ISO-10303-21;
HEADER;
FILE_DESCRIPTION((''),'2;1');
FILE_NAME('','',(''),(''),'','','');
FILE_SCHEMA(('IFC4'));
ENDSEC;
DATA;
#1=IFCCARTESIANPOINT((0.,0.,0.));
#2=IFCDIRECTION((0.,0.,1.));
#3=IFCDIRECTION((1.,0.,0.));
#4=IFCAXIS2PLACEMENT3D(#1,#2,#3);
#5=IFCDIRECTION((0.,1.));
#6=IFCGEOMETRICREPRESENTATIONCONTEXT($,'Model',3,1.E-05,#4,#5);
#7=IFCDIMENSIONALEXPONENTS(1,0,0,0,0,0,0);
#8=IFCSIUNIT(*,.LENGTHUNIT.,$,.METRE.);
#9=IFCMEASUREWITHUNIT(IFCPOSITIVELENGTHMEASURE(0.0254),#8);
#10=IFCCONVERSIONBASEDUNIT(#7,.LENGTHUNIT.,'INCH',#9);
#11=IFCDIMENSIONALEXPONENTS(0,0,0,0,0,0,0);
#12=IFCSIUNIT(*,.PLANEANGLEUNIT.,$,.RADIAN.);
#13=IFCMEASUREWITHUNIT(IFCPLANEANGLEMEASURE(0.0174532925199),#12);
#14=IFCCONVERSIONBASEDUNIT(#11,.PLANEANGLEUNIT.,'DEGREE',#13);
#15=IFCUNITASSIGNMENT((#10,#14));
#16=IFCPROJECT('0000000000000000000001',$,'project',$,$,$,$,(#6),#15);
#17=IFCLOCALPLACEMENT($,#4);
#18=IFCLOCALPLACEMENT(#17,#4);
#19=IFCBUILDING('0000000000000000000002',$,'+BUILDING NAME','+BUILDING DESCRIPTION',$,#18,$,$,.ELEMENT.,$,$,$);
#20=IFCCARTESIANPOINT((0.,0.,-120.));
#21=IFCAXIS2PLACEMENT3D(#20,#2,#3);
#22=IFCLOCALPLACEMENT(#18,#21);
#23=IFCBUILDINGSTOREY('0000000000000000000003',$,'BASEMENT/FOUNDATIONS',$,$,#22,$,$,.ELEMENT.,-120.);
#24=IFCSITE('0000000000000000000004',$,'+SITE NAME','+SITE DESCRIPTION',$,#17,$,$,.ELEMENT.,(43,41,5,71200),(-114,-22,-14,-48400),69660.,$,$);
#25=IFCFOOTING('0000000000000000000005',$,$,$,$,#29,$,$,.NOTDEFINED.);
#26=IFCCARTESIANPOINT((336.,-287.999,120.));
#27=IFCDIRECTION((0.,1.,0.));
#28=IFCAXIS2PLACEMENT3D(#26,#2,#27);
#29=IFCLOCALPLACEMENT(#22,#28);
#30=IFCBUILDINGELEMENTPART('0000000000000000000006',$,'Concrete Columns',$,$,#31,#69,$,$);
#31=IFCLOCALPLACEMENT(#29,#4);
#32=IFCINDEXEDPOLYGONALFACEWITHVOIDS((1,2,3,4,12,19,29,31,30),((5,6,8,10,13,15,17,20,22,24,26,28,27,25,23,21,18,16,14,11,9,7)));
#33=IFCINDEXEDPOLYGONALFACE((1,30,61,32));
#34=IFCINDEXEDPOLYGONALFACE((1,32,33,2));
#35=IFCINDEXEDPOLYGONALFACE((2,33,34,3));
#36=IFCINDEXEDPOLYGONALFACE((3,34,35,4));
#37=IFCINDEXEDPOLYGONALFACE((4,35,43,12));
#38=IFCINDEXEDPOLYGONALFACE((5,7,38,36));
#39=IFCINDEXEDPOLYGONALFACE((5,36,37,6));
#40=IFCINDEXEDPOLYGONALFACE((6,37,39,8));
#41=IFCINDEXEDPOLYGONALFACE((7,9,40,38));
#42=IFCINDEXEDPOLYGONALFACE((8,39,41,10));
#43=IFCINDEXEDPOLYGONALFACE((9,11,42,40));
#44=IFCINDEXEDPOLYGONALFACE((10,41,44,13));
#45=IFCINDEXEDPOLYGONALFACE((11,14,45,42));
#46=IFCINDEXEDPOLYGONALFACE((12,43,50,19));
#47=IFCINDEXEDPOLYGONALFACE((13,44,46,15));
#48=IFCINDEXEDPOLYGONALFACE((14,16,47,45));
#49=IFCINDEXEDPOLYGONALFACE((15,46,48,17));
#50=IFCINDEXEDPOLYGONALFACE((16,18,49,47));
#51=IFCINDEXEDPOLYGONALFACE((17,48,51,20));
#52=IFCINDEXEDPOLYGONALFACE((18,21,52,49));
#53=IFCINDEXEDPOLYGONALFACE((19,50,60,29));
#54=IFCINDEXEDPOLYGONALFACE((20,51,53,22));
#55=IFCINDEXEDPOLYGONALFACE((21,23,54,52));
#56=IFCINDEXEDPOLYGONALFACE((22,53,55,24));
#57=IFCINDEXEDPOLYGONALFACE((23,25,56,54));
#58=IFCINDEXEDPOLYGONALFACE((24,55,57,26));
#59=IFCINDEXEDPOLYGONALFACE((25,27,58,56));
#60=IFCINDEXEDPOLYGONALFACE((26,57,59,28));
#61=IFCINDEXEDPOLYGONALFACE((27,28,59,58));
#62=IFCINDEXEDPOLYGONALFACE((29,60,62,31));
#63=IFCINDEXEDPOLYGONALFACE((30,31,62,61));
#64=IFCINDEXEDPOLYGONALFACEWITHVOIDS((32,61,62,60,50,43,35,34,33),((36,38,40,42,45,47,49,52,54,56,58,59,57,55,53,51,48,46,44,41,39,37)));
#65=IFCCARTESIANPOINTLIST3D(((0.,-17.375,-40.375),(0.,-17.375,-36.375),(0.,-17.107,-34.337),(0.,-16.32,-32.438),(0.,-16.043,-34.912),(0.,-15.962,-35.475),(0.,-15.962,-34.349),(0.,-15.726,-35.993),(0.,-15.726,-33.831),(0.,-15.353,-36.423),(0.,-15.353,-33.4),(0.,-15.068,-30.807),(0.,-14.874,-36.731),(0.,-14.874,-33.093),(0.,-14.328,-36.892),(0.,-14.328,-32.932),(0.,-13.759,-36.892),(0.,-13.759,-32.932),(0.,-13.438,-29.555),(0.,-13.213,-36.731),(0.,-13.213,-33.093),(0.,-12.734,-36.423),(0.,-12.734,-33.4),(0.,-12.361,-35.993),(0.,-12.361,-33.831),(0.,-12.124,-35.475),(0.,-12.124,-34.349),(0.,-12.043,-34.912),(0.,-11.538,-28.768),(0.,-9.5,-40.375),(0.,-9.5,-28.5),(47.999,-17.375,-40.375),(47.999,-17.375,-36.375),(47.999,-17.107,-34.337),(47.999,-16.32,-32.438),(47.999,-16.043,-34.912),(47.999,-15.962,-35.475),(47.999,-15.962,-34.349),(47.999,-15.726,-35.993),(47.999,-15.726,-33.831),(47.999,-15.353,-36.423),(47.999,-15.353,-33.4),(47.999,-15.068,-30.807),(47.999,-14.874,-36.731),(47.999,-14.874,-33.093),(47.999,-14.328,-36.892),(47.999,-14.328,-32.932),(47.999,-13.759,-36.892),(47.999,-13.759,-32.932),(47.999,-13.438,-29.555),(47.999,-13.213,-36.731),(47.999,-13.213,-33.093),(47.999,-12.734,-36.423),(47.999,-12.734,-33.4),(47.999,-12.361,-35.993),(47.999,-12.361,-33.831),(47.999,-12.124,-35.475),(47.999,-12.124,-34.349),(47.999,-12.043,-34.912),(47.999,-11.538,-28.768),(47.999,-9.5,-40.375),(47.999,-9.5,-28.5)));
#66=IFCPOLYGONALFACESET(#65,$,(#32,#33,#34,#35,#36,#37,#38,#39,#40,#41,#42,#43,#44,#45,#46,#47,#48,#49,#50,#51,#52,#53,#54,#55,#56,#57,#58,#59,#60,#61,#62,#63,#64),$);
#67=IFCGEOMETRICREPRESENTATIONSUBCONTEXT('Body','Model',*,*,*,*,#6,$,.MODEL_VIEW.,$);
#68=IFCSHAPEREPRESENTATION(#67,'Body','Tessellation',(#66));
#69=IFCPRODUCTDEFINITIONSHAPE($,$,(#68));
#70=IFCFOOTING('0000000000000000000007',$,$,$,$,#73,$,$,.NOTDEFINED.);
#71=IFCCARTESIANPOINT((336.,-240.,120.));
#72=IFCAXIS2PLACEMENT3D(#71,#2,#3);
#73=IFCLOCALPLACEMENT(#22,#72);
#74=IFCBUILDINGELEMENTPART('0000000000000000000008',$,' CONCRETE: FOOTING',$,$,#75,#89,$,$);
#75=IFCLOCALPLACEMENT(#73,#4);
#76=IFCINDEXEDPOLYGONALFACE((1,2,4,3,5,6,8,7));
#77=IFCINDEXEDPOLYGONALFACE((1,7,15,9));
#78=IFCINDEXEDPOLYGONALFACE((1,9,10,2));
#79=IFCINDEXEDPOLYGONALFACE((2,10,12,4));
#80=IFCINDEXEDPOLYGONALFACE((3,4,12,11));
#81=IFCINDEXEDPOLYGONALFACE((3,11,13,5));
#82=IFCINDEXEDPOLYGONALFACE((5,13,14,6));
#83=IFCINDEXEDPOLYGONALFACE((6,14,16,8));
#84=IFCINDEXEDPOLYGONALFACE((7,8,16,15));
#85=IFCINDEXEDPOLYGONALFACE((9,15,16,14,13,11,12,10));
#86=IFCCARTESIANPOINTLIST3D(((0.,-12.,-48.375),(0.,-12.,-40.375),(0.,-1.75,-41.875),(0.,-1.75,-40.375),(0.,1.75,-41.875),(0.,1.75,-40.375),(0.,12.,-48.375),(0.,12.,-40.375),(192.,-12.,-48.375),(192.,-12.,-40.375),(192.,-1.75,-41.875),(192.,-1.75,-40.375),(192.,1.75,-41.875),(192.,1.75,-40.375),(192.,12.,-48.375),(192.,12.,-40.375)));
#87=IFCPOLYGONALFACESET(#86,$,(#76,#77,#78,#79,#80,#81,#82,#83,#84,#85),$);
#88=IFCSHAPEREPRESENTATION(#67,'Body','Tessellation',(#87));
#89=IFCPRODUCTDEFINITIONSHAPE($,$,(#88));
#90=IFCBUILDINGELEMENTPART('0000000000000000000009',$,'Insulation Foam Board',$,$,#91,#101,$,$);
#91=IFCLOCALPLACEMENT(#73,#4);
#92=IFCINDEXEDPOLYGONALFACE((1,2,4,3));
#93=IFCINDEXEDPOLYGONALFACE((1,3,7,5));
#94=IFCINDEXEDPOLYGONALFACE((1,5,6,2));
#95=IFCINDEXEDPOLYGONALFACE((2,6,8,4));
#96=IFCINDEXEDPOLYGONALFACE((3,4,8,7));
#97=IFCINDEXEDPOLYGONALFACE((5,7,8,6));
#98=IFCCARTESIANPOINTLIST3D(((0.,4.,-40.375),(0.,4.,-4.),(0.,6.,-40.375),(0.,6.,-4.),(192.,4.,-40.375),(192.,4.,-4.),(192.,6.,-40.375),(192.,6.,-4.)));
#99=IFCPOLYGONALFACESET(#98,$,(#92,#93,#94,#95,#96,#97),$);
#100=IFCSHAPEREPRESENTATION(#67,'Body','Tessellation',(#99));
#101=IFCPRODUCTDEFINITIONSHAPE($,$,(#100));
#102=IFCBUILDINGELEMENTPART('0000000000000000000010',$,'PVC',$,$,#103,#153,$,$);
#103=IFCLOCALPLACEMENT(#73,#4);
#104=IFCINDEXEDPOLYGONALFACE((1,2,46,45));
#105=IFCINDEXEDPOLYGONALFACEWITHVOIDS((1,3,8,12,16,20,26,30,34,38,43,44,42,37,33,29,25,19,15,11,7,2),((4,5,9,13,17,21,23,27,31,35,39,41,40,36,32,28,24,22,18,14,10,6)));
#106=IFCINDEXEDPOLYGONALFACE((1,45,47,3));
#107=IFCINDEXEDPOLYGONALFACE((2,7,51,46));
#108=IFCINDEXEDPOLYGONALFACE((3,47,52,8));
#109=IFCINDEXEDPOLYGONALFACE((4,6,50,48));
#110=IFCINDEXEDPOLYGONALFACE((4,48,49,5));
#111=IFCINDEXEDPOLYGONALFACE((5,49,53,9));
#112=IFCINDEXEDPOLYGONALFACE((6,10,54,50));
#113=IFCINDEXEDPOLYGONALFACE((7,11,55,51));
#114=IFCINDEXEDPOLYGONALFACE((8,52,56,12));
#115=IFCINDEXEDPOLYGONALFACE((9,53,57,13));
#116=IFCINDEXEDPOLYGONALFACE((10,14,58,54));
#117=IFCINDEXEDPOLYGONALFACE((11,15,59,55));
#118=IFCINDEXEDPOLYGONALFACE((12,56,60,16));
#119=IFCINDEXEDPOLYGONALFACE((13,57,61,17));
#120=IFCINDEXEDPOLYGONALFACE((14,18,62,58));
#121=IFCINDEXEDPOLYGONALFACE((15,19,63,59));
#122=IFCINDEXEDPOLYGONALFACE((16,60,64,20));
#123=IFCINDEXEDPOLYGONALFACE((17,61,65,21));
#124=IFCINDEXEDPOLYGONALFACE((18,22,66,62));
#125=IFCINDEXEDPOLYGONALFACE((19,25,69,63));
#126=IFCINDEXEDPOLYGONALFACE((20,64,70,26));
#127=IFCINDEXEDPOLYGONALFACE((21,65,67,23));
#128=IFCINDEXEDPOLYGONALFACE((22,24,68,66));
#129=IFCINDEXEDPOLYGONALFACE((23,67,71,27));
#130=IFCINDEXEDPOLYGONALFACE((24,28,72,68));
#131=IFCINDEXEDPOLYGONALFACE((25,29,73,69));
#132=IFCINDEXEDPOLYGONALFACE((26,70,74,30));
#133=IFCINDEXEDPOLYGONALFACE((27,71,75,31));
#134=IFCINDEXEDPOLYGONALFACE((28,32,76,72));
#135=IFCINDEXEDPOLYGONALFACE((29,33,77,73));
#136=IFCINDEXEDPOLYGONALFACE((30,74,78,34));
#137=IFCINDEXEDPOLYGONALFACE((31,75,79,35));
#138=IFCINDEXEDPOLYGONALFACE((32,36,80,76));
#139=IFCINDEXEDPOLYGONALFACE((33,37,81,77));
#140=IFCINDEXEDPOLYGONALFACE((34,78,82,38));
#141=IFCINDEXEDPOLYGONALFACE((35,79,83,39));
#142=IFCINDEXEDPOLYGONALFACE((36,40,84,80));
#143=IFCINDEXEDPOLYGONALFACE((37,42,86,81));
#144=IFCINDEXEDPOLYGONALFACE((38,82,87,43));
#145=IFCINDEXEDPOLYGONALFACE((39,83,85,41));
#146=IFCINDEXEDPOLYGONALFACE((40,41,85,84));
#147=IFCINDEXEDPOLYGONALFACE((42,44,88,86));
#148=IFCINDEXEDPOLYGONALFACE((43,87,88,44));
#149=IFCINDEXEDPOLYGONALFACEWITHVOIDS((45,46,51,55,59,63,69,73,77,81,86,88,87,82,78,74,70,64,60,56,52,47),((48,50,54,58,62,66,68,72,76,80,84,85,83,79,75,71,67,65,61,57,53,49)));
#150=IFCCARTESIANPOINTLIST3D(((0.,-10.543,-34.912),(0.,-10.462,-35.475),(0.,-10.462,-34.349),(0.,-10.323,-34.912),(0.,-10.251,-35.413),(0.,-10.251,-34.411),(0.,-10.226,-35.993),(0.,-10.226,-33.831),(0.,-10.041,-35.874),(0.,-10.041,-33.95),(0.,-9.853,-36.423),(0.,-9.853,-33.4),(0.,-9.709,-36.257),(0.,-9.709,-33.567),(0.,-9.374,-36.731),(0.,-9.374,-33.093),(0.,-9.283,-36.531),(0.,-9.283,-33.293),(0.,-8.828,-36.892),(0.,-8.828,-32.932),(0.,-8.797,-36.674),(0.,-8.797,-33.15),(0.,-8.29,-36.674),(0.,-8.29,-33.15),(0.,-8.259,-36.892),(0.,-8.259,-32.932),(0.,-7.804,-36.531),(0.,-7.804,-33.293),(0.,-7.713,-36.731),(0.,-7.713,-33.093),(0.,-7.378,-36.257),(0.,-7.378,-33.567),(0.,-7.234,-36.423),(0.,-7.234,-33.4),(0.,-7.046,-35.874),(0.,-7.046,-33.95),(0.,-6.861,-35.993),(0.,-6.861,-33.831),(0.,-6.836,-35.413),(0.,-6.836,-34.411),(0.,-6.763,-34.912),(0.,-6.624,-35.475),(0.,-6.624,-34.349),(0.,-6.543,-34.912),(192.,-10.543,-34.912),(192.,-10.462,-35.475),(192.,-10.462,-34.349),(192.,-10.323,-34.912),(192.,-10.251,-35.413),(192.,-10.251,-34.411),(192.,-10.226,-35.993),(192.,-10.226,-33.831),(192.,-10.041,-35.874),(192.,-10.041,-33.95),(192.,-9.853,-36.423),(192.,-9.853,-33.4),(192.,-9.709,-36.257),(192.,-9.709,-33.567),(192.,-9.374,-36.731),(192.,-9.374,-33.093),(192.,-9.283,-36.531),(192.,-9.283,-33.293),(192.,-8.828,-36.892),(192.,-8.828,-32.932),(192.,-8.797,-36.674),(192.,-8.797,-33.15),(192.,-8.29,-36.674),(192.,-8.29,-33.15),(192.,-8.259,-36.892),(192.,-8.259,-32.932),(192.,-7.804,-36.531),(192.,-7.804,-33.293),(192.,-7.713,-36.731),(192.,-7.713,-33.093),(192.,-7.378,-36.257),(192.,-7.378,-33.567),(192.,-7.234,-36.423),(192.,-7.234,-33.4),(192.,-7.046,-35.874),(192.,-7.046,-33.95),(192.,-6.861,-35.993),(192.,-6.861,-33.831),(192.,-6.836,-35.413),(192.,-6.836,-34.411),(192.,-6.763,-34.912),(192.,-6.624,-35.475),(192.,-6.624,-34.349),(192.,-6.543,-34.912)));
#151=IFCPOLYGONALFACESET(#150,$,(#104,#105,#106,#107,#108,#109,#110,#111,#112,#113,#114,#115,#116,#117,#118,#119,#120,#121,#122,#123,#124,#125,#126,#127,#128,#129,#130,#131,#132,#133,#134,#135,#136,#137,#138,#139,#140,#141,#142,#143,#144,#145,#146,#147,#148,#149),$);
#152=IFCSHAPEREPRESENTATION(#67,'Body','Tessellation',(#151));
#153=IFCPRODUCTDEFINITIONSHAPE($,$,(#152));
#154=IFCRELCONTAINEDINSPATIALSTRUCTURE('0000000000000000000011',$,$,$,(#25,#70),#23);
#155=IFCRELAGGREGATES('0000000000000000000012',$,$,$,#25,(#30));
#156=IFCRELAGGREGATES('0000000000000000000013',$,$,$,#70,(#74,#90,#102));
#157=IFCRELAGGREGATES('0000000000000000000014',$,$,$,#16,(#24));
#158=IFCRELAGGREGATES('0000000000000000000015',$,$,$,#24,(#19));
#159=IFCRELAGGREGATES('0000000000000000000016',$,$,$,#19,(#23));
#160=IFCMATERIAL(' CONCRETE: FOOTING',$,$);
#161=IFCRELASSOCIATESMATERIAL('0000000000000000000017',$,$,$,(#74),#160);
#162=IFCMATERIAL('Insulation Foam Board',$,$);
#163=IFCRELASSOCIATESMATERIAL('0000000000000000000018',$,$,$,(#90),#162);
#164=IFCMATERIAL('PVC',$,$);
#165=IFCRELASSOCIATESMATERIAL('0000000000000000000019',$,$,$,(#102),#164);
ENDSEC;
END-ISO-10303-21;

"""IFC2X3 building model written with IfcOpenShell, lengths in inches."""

from ifc_helpers import new_model, entity, si_unit, converted_unit, point, direction, frame, frame_2d, origin_with_axes, place, context, subcontext, project, spatial, polyline, circle_curve, parameter, trimmed, segment, composite_curve, outline, extrude, material, element, aggregate, save


model = new_model("IFC2X3")

# Units and contexts
model_context = context("Model", 3, precision=1e-05, world=origin_with_axes(), true_north=direction((0.0, 1.0)))
body_context = subcontext(model_context, "Body", "Model", "MODEL_VIEW")
ifc_project = project(units=[converted_unit("LENGTHUNIT", "INCH", entity("IfcPositiveLengthMeasure", 0.0254), si_unit("LENGTHUNIT", "METRE"), dimensions=[1, 0, 0, 0, 0, 0, 0]), converted_unit("PLANEANGLEUNIT", "DEGREE", entity("IfcPlaneAngleMeasure", 0.0174532925199), si_unit("PLANEANGLEUNIT", "RADIAN"), dimensions=[0, 0, 0, 0, 0, 0, 0])], contexts=[model_context])

# Site, building, storey
site_placement = place(None, origin_with_axes())
site = spatial("IfcSite", under=ifc_project, at=site_placement, Name="+SITE NAME", Description="+SITE DESCRIPTION", CompositionType="ELEMENT", RefLatitude=(43, 41, 5, 71200), RefLongitude=(-114, -22, -14, -48400), RefElevation=69660.0)
building_placement = place(site_placement, origin_with_axes())
building = spatial("IfcBuilding", under=site, at=building_placement, Name="+BUILDING NAME", Description="+BUILDING DESCRIPTION", CompositionType="ELEMENT")
storey_placement = place(building_placement, frame((0.0, 0.0, -120.0), z_axis=(0.0, 0.0, 1.0), x_axis=(1.0, 0.0, 0.0)))
storey = spatial("IfcBuildingStorey", under=building, at=storey_placement, Name="BASEMENT/FOUNDATIONS", CompositionType="ELEMENT", Elevation=-120.0)

# Footings, building element parts
ifc_material_1 = material(Name=" CONCRETE: FOOTING")
footing_1_placement = place(storey_placement, frame((336.0, -287.999, 120.0), z_axis=(0.0, 0.0, 1.0), x_axis=(0.0, 1.0, 0.0)))
footing_1 = element("IfcFooting", 1, at=footing_1_placement, inside=storey, PredefinedType="NOTDEFINED")
ifc_material_2 = material(Name="Insulation Foam Board")
ifc_material_3 = material(Name="PVC")
building_element_part_1_placement = place(footing_1_placement, origin_with_axes())
building_element_part_1 = element("IfcBuildingElementPart", 2, at=building_element_part_1_placement, Name="Concrete Columns", context=body_context, shape_type="SweptSolid", body=[
    extrude(outline(composite_curve([segment(trimmed(circle_curve(frame_2d((9.5, -36.375), x_axis=(1.0, 0.0)), 7.875), [point((17.375, -36.375)), parameter(0.0)], [point((9.5, -28.5)), parameter(90.0)], True, "CARTESIAN"), True, "CONTINUOUS"), segment(polyline([(9.5, -28.5), (9.5, -40.375), (17.375, -40.375), (17.375, -36.375)]), True, "CONTINUOUS")], self_intersect=False), holes=[composite_curve([segment(trimmed(circle_curve(frame_2d((14.043, -34.912), x_axis=(-1.0, 0.0)), 2.0), [point((16.043, -34.912)), parameter(180.0)], [point((12.043, -34.912)), parameter(0.0)], False, "CARTESIAN"), True, "CONTINUOUS"), segment(trimmed(circle_curve(frame_2d((14.043, -34.912), x_axis=(1.0, 0.0)), 2.0), [point((12.043, -34.912)), parameter(180.0)], [point((16.043, -34.912)), parameter(0.0)], False, "CARTESIAN"), True, "CONTINUOUS")], self_intersect=False)]), frame((0.0, 0.0, 0.0), z_axis=(-1.0, 0.0, 0.0), x_axis=(0.0, -1.0, 0.0)), (0.0, 0.0, -1.0), 47.999),
])
aggregate(footing_1, [building_element_part_1])
footing_2_placement = place(storey_placement, frame((336.0, -240.0, 120.0), z_axis=(0.0, 0.0, 1.0), x_axis=(1.0, 0.0, 0.0)))
footing_2 = element("IfcFooting", 3, at=footing_2_placement, inside=storey, PredefinedType="NOTDEFINED")
building_element_part_2_placement = place(footing_2_placement, origin_with_axes())
building_element_part_2 = element("IfcBuildingElementPart", 4, at=building_element_part_2_placement, material=ifc_material_1, Name=" CONCRETE: FOOTING", context=body_context, shape_type="SweptSolid", body=[
    extrude(outline(polyline([(-12.0, -48.375), (12.0, -48.375), (12.0, -40.375), (1.75, -40.375), (1.75, -41.875), (-1.75, -41.875), (-1.75, -40.375), (-12.0, -40.375), (-12.0, -48.375)])), frame((0.0, 0.0, 0.0), z_axis=(-1.0, 0.0, 0.0), x_axis=(0.0, -1.0, 0.0)), (0.0, 0.0, -1.0), 192.0),
])
building_element_part_3_placement = place(footing_2_placement, origin_with_axes())
building_element_part_3 = element("IfcBuildingElementPart", 5, at=building_element_part_3_placement, material=ifc_material_2, Name="Insulation Foam Board", context=body_context, shape_type="SweptSolid", body=[
    extrude(outline(polyline([(-4.0, -4.0), (-6.0, -4.0), (-6.0, -40.375), (-4.0, -40.375), (-4.0, -4.0)])), frame((0.0, 0.0, 0.0), z_axis=(-1.0, 0.0, 0.0), x_axis=(0.0, -1.0, 0.0)), (0.0, 0.0, -1.0), 192.0),
])
building_element_part_4_placement = place(footing_2_placement, origin_with_axes())
building_element_part_4 = element("IfcBuildingElementPart", 6, at=building_element_part_4_placement, material=ifc_material_3, Name="PVC", context=body_context, shape_type="SweptSolid", body=[
    extrude(outline(composite_curve([segment(trimmed(circle_curve(frame_2d((8.543, -34.912), x_axis=(1.0, 0.0)), 2.0), [point((10.543, -34.912)), parameter(0.0)], [point((6.543, -34.912)), parameter(180.0)], True, "CARTESIAN"), True, "CONTINUOUS"), segment(trimmed(circle_curve(frame_2d((8.543, -34.912), x_axis=(-1.0, 0.0)), 2.0), [point((6.543, -34.912)), parameter(0.0)], [point((10.543, -34.912)), parameter(180.0)], True, "CARTESIAN"), True, "CONTINUOUS")], self_intersect=False), holes=[composite_curve([segment(trimmed(circle_curve(frame_2d((8.543, -34.912), x_axis=(-1.0, 0.0)), 1.78), [point((10.323, -34.912)), parameter(180.0)], [point((6.763, -34.912)), parameter(0.0)], False, "CARTESIAN"), True, "CONTINUOUS"), segment(trimmed(circle_curve(frame_2d((8.543, -34.912), x_axis=(1.0, 0.0)), 1.78), [point((6.763, -34.912)), parameter(180.0)], [point((10.323, -34.912)), parameter(0.0)], False, "CARTESIAN"), True, "CONTINUOUS")], self_intersect=False)]), frame((0.0, 0.0, 0.0), z_axis=(-1.0, 0.0, 0.0), x_axis=(0.0, -1.0, 0.0)), (0.0, 0.0, -1.0), 192.0),
])
aggregate(footing_2, [building_element_part_2, building_element_part_3, building_element_part_4])

save(model, "model.ifc")
